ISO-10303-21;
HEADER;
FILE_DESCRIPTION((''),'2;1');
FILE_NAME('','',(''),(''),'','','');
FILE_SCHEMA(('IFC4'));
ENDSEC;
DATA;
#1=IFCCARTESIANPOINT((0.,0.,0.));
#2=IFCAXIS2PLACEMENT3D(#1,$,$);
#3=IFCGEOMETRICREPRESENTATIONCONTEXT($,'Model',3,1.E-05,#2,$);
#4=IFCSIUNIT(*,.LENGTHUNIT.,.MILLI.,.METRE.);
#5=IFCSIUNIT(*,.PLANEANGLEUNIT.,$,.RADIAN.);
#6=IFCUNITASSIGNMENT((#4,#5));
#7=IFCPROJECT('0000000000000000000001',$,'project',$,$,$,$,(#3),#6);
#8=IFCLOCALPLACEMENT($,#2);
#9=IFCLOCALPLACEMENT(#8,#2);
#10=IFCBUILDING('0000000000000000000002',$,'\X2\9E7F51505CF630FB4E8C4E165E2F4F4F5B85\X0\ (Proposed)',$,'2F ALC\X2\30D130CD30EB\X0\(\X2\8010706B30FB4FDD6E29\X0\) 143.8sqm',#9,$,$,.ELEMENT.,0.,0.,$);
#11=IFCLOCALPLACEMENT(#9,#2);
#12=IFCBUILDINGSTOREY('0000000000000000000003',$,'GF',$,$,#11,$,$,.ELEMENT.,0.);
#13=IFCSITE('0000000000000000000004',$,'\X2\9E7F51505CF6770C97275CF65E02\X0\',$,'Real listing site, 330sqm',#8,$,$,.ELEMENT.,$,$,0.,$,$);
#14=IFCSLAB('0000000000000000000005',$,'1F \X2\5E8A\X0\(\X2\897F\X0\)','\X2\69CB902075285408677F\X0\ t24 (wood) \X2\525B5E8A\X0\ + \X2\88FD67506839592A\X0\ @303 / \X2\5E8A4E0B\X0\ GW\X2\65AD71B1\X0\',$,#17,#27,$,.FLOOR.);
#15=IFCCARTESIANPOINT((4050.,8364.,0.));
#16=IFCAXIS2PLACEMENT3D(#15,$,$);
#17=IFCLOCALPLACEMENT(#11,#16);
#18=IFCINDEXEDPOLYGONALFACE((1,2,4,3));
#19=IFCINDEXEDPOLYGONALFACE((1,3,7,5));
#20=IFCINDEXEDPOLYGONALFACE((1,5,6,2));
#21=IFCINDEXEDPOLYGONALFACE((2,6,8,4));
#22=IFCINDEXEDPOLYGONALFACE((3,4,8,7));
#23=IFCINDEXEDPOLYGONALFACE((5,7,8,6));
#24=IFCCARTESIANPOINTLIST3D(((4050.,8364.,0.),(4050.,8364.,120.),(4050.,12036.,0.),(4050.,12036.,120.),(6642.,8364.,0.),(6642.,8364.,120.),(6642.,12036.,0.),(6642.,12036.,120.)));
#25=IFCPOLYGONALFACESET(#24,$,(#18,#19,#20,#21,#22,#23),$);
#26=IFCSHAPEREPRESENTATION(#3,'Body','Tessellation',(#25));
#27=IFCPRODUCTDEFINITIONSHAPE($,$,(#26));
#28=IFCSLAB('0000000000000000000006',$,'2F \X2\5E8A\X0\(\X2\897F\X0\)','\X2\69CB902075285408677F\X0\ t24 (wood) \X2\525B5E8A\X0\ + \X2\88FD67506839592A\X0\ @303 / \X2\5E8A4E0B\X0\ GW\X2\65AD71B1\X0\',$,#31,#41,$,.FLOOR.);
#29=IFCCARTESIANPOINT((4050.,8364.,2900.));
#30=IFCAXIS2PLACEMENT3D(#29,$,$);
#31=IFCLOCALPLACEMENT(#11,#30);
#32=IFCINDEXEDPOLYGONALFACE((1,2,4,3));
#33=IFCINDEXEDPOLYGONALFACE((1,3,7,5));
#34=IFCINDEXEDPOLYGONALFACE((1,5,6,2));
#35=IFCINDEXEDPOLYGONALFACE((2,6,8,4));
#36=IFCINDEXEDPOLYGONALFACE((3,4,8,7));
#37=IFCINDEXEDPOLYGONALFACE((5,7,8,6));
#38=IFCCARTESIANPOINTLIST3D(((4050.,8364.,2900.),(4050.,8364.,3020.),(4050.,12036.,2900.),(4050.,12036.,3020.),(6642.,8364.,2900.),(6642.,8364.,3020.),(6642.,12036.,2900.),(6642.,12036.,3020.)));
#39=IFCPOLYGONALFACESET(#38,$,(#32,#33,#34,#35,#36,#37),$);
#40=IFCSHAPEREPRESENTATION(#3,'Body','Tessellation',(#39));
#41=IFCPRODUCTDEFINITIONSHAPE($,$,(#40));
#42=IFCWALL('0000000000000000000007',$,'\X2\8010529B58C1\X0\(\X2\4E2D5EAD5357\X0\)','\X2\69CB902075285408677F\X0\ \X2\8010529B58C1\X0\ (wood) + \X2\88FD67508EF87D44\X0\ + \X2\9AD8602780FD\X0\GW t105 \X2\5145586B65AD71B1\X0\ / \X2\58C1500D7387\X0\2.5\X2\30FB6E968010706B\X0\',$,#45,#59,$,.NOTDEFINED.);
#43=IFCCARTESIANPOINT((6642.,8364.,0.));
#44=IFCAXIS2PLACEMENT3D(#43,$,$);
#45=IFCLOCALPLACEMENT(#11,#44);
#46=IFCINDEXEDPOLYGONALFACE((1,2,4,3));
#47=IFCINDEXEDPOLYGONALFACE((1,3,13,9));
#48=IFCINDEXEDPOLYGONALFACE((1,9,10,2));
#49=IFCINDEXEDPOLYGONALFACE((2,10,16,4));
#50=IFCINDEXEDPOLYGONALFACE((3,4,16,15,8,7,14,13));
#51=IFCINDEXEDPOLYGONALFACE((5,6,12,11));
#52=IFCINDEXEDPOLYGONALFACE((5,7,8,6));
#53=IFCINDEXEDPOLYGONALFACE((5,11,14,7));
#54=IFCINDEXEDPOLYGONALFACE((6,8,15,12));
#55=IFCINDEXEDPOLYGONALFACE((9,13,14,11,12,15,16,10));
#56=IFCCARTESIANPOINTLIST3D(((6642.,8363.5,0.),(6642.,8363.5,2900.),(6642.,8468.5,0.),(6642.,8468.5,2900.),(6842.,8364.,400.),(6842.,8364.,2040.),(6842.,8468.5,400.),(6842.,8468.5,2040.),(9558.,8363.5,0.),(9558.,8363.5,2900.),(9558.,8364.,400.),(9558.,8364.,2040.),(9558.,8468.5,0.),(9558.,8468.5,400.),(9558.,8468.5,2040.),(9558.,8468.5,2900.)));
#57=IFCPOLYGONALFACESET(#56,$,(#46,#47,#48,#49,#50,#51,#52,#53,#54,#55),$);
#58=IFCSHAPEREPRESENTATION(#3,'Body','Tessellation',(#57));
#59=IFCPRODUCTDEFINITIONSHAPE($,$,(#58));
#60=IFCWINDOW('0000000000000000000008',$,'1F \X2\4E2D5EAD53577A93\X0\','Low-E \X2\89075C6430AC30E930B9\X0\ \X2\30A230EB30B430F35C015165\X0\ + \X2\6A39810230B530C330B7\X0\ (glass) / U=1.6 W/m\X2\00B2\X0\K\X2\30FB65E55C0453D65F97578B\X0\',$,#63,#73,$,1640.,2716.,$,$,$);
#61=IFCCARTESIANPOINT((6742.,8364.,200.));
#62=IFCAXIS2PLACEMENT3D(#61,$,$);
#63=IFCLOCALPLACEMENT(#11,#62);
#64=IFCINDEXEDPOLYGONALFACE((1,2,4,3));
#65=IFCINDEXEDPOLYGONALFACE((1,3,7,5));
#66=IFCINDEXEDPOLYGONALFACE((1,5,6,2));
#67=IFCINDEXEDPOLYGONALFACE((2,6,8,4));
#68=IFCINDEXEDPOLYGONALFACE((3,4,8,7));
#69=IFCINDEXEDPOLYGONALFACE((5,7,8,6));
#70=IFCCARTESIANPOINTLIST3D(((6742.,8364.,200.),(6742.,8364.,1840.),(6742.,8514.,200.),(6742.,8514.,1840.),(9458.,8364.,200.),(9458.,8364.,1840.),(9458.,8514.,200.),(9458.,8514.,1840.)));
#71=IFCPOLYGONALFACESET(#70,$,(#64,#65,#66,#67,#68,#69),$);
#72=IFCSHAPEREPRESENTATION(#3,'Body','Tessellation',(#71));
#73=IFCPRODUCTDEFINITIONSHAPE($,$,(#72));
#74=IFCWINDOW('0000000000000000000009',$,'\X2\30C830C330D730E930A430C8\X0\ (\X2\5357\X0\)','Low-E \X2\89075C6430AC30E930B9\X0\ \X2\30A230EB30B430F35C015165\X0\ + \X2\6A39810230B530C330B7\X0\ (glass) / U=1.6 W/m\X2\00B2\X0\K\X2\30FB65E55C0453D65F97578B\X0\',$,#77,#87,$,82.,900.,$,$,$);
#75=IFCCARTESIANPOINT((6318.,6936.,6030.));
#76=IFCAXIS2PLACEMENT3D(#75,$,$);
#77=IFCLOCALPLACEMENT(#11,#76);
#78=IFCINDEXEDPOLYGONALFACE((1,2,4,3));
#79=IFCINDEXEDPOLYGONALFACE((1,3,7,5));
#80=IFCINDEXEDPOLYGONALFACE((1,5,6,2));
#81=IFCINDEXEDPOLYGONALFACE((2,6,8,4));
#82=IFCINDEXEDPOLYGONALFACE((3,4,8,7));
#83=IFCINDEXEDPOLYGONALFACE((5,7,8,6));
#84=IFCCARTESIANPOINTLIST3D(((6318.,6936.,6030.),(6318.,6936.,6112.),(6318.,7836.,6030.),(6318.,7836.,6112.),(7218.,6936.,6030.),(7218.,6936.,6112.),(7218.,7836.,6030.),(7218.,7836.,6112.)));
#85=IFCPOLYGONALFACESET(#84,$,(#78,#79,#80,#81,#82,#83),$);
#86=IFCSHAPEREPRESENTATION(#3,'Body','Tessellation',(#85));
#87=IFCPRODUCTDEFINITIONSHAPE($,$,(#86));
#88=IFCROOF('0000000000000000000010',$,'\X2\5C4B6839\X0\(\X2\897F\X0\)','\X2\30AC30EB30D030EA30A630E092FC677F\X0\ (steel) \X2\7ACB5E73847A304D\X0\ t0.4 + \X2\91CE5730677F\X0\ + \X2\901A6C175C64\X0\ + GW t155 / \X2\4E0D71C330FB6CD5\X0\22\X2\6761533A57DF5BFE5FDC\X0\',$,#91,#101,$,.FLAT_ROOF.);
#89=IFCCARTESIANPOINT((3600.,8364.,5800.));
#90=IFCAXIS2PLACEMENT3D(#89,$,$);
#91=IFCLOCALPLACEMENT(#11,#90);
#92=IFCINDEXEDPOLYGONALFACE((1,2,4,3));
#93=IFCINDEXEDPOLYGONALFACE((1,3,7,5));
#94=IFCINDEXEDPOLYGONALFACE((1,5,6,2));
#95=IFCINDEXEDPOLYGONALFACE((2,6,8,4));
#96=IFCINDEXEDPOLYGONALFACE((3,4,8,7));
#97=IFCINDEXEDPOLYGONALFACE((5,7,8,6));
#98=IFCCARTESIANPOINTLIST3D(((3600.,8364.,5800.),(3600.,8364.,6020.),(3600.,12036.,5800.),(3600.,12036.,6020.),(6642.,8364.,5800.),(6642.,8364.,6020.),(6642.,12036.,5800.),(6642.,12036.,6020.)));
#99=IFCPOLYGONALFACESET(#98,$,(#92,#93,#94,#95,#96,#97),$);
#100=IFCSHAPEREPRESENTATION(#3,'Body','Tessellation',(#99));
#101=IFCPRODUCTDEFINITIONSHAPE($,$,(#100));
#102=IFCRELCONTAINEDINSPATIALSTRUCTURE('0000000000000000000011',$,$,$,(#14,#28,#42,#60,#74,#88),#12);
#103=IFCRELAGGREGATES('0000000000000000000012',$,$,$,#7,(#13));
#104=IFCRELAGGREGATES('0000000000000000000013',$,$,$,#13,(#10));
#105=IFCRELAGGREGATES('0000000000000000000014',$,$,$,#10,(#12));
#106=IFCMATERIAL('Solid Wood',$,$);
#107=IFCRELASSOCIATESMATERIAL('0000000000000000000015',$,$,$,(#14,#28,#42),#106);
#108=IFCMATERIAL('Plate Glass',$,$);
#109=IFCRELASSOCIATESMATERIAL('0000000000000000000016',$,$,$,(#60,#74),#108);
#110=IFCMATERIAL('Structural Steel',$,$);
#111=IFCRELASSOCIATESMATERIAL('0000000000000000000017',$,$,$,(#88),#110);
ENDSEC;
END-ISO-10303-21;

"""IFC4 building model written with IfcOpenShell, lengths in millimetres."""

from ifc_helpers import new_model, si_unit, frame, frame_2d, origin, place, context, project, spatial, rectangle, extrude, material, element, fill, save


model = new_model("IFC4")

# Units and contexts
model_context = context("Model", 3, precision=1e-05, world=origin())
ifc_project = project(units=[si_unit("LENGTHUNIT", "METRE", prefix="MILLI"), si_unit("PLANEANGLEUNIT", "RADIAN")], contexts=[model_context])

# Site, building, storey
site_placement = place(None, origin())
site = spatial("IfcSite", under=ifc_project, at=site_placement, Name="鹿児島県霧島市", ObjectType="Real listing site, 330sqm", CompositionType="ELEMENT", RefElevation=0.0)
building_placement = place(site_placement, origin())
building = spatial("IfcBuilding", under=site, at=building_placement, Name="鹿児島・二世帯住宅 (Proposed)", ObjectType="2F ALCパネル(耐火・保温) 143.8sqm", CompositionType="ELEMENT", ElevationOfRefHeight=0.0, ElevationOfTerrain=0.0)
storey_placement = place(building_placement, origin())
storey = spatial("IfcBuildingStorey", under=building, at=storey_placement, Name="GF", CompositionType="ELEMENT", Elevation=0.0)

# Shared definitions
ifc_material_1 = material(Name="Solid Wood")

# Slabs
slab_1_placement = place(storey_placement, frame((4050.0, 8364.0, 0.0)))
element("IfcSlab", 1, at=slab_1_placement, inside=storey, material=ifc_material_1, Name="1F 床(西)", Description="構造用合板 t24 (wood) 剛床 + 製材根太 @303 / 床下 GW断熱", PredefinedType="FLOOR", context=model_context, shape_type="SweptSolid", body=[
    extrude(rectangle(XDim=2592.0, YDim=3672.0, at=frame_2d((1296.0, 1836.0))), frame((4050.0, 8364.0, 0.0)), (0.0, 0.0, 1.0), 120.0),
])
slab_2_placement = place(storey_placement, frame((4050.0, 8364.0, 2900.0)))
element("IfcSlab", 2, at=slab_2_placement, inside=storey, material=ifc_material_1, Name="2F 床(西)", Description="構造用合板 t24 (wood) 剛床 + 製材根太 @303 / 床下 GW断熱", PredefinedType="FLOOR", context=model_context, shape_type="SweptSolid", body=[
    extrude(rectangle(XDim=2592.0, YDim=3672.0, at=frame_2d((1296.0, 1836.0))), frame((4050.0, 8364.0, 2900.0)), (0.0, 0.0, 1.0), 120.0),
])

# Wall, opening, window
wall_1_placement = place(storey_placement, frame((6642.0, 8364.0, 0.0)))
wall_1 = element("IfcWall", 3, at=wall_1_placement, inside=storey, material=ifc_material_1, Name="耐力壁(中庭南)", Description="構造用合板 耐力壁 (wood) + 製材軸組 + 高性能GW t105 充填断熱 / 壁倍率2.5・準耐火", PredefinedType="NOTDEFINED", context=model_context, shape_type="SweptSolid", body=[
    extrude(rectangle(XDim=2916.0, YDim=105.0, at=frame_2d((1458.0, 52.0))), frame((6642.0, 8364.0, 0.0)), (0.0, 0.0, 1.0), 2900.0),
])
opening_placement = place(storey_placement, frame((6742.0, 8364.0, 200.0)))
opening = element("IfcOpeningElement", 4, at=opening_placement, cuts=wall_1, PredefinedType="NOTDEFINED", context=model_context, shape_type="SweptSolid", body=[
    extrude(rectangle(XDim=2716.0, YDim=150.0, at=frame_2d((1358.0, 75.0))), frame((6742.0, 8364.0, 200.0)), (0.0, 0.0, 1.0), 1640.0),
])
ifc_material_2 = material(Name="Plate Glass")
window_1_placement = place(storey_placement, frame((6742.0, 8364.0, 200.0)))
window_1 = element("IfcWindow", 5, at=window_1_placement, inside=storey, material=ifc_material_2, Name="1F 中庭南窓", Description="Low-E 複層ガラス アルゴン封入 + 樹脂サッシ (glass) / U=1.6 W/m²K・日射取得型", OverallHeight=1640.0, OverallWidth=2716.0, context=model_context, shape_type="SweptSolid", body=[
    extrude(rectangle(XDim=2716.0, YDim=150.0, at=frame_2d((1358.0, 75.0))), frame((6742.0, 8364.0, 200.0)), (0.0, 0.0, 1.0), 1640.0),
])
fill(opening, window_1)

# Window
window_2_placement = place(storey_placement, frame((6318.0, 6936.0, 6030.0)))
element("IfcWindow", 6, at=window_2_placement, inside=storey, material=ifc_material_2, Name="トップライト (南)", Description="Low-E 複層ガラス アルゴン封入 + 樹脂サッシ (glass) / U=1.6 W/m²K・日射取得型", OverallHeight=82.0, OverallWidth=900.0, context=model_context, shape_type="SweptSolid", body=[
    extrude(rectangle(XDim=900.0, YDim=900.0, at=frame_2d((450.0, 450.0))), frame((6318.0, 6936.0, 6030.0)), (0.0, 0.0, 1.0), 82.0),
])

# Roof
ifc_material_3 = material(Name="Structural Steel")
for number, where, name in (
    (7, (3600.0, 8364.0, 5800.0), "屋根(西)"),
):
    element("IfcRoof", number, at=place(storey_placement, frame(where)), inside=storey, material=ifc_material_3, Name=name, Description="ガルバリウム鋼板 (steel) 立平葺き t0.4 + 野地板 + 通気層 + GW t155 / 不燃・法22条区域対応", PredefinedType="FLAT_ROOF", context=model_context, shape_type="SweptSolid", body=[
        extrude(rectangle(XDim=3042.0, YDim=3672.0, at=frame_2d((1521.0, 1836.0))), frame((3600.0, 8364.0, 5800.0)), (0.0, 0.0, 1.0), 220.0),
    ])

save(model, "model.ifc")
